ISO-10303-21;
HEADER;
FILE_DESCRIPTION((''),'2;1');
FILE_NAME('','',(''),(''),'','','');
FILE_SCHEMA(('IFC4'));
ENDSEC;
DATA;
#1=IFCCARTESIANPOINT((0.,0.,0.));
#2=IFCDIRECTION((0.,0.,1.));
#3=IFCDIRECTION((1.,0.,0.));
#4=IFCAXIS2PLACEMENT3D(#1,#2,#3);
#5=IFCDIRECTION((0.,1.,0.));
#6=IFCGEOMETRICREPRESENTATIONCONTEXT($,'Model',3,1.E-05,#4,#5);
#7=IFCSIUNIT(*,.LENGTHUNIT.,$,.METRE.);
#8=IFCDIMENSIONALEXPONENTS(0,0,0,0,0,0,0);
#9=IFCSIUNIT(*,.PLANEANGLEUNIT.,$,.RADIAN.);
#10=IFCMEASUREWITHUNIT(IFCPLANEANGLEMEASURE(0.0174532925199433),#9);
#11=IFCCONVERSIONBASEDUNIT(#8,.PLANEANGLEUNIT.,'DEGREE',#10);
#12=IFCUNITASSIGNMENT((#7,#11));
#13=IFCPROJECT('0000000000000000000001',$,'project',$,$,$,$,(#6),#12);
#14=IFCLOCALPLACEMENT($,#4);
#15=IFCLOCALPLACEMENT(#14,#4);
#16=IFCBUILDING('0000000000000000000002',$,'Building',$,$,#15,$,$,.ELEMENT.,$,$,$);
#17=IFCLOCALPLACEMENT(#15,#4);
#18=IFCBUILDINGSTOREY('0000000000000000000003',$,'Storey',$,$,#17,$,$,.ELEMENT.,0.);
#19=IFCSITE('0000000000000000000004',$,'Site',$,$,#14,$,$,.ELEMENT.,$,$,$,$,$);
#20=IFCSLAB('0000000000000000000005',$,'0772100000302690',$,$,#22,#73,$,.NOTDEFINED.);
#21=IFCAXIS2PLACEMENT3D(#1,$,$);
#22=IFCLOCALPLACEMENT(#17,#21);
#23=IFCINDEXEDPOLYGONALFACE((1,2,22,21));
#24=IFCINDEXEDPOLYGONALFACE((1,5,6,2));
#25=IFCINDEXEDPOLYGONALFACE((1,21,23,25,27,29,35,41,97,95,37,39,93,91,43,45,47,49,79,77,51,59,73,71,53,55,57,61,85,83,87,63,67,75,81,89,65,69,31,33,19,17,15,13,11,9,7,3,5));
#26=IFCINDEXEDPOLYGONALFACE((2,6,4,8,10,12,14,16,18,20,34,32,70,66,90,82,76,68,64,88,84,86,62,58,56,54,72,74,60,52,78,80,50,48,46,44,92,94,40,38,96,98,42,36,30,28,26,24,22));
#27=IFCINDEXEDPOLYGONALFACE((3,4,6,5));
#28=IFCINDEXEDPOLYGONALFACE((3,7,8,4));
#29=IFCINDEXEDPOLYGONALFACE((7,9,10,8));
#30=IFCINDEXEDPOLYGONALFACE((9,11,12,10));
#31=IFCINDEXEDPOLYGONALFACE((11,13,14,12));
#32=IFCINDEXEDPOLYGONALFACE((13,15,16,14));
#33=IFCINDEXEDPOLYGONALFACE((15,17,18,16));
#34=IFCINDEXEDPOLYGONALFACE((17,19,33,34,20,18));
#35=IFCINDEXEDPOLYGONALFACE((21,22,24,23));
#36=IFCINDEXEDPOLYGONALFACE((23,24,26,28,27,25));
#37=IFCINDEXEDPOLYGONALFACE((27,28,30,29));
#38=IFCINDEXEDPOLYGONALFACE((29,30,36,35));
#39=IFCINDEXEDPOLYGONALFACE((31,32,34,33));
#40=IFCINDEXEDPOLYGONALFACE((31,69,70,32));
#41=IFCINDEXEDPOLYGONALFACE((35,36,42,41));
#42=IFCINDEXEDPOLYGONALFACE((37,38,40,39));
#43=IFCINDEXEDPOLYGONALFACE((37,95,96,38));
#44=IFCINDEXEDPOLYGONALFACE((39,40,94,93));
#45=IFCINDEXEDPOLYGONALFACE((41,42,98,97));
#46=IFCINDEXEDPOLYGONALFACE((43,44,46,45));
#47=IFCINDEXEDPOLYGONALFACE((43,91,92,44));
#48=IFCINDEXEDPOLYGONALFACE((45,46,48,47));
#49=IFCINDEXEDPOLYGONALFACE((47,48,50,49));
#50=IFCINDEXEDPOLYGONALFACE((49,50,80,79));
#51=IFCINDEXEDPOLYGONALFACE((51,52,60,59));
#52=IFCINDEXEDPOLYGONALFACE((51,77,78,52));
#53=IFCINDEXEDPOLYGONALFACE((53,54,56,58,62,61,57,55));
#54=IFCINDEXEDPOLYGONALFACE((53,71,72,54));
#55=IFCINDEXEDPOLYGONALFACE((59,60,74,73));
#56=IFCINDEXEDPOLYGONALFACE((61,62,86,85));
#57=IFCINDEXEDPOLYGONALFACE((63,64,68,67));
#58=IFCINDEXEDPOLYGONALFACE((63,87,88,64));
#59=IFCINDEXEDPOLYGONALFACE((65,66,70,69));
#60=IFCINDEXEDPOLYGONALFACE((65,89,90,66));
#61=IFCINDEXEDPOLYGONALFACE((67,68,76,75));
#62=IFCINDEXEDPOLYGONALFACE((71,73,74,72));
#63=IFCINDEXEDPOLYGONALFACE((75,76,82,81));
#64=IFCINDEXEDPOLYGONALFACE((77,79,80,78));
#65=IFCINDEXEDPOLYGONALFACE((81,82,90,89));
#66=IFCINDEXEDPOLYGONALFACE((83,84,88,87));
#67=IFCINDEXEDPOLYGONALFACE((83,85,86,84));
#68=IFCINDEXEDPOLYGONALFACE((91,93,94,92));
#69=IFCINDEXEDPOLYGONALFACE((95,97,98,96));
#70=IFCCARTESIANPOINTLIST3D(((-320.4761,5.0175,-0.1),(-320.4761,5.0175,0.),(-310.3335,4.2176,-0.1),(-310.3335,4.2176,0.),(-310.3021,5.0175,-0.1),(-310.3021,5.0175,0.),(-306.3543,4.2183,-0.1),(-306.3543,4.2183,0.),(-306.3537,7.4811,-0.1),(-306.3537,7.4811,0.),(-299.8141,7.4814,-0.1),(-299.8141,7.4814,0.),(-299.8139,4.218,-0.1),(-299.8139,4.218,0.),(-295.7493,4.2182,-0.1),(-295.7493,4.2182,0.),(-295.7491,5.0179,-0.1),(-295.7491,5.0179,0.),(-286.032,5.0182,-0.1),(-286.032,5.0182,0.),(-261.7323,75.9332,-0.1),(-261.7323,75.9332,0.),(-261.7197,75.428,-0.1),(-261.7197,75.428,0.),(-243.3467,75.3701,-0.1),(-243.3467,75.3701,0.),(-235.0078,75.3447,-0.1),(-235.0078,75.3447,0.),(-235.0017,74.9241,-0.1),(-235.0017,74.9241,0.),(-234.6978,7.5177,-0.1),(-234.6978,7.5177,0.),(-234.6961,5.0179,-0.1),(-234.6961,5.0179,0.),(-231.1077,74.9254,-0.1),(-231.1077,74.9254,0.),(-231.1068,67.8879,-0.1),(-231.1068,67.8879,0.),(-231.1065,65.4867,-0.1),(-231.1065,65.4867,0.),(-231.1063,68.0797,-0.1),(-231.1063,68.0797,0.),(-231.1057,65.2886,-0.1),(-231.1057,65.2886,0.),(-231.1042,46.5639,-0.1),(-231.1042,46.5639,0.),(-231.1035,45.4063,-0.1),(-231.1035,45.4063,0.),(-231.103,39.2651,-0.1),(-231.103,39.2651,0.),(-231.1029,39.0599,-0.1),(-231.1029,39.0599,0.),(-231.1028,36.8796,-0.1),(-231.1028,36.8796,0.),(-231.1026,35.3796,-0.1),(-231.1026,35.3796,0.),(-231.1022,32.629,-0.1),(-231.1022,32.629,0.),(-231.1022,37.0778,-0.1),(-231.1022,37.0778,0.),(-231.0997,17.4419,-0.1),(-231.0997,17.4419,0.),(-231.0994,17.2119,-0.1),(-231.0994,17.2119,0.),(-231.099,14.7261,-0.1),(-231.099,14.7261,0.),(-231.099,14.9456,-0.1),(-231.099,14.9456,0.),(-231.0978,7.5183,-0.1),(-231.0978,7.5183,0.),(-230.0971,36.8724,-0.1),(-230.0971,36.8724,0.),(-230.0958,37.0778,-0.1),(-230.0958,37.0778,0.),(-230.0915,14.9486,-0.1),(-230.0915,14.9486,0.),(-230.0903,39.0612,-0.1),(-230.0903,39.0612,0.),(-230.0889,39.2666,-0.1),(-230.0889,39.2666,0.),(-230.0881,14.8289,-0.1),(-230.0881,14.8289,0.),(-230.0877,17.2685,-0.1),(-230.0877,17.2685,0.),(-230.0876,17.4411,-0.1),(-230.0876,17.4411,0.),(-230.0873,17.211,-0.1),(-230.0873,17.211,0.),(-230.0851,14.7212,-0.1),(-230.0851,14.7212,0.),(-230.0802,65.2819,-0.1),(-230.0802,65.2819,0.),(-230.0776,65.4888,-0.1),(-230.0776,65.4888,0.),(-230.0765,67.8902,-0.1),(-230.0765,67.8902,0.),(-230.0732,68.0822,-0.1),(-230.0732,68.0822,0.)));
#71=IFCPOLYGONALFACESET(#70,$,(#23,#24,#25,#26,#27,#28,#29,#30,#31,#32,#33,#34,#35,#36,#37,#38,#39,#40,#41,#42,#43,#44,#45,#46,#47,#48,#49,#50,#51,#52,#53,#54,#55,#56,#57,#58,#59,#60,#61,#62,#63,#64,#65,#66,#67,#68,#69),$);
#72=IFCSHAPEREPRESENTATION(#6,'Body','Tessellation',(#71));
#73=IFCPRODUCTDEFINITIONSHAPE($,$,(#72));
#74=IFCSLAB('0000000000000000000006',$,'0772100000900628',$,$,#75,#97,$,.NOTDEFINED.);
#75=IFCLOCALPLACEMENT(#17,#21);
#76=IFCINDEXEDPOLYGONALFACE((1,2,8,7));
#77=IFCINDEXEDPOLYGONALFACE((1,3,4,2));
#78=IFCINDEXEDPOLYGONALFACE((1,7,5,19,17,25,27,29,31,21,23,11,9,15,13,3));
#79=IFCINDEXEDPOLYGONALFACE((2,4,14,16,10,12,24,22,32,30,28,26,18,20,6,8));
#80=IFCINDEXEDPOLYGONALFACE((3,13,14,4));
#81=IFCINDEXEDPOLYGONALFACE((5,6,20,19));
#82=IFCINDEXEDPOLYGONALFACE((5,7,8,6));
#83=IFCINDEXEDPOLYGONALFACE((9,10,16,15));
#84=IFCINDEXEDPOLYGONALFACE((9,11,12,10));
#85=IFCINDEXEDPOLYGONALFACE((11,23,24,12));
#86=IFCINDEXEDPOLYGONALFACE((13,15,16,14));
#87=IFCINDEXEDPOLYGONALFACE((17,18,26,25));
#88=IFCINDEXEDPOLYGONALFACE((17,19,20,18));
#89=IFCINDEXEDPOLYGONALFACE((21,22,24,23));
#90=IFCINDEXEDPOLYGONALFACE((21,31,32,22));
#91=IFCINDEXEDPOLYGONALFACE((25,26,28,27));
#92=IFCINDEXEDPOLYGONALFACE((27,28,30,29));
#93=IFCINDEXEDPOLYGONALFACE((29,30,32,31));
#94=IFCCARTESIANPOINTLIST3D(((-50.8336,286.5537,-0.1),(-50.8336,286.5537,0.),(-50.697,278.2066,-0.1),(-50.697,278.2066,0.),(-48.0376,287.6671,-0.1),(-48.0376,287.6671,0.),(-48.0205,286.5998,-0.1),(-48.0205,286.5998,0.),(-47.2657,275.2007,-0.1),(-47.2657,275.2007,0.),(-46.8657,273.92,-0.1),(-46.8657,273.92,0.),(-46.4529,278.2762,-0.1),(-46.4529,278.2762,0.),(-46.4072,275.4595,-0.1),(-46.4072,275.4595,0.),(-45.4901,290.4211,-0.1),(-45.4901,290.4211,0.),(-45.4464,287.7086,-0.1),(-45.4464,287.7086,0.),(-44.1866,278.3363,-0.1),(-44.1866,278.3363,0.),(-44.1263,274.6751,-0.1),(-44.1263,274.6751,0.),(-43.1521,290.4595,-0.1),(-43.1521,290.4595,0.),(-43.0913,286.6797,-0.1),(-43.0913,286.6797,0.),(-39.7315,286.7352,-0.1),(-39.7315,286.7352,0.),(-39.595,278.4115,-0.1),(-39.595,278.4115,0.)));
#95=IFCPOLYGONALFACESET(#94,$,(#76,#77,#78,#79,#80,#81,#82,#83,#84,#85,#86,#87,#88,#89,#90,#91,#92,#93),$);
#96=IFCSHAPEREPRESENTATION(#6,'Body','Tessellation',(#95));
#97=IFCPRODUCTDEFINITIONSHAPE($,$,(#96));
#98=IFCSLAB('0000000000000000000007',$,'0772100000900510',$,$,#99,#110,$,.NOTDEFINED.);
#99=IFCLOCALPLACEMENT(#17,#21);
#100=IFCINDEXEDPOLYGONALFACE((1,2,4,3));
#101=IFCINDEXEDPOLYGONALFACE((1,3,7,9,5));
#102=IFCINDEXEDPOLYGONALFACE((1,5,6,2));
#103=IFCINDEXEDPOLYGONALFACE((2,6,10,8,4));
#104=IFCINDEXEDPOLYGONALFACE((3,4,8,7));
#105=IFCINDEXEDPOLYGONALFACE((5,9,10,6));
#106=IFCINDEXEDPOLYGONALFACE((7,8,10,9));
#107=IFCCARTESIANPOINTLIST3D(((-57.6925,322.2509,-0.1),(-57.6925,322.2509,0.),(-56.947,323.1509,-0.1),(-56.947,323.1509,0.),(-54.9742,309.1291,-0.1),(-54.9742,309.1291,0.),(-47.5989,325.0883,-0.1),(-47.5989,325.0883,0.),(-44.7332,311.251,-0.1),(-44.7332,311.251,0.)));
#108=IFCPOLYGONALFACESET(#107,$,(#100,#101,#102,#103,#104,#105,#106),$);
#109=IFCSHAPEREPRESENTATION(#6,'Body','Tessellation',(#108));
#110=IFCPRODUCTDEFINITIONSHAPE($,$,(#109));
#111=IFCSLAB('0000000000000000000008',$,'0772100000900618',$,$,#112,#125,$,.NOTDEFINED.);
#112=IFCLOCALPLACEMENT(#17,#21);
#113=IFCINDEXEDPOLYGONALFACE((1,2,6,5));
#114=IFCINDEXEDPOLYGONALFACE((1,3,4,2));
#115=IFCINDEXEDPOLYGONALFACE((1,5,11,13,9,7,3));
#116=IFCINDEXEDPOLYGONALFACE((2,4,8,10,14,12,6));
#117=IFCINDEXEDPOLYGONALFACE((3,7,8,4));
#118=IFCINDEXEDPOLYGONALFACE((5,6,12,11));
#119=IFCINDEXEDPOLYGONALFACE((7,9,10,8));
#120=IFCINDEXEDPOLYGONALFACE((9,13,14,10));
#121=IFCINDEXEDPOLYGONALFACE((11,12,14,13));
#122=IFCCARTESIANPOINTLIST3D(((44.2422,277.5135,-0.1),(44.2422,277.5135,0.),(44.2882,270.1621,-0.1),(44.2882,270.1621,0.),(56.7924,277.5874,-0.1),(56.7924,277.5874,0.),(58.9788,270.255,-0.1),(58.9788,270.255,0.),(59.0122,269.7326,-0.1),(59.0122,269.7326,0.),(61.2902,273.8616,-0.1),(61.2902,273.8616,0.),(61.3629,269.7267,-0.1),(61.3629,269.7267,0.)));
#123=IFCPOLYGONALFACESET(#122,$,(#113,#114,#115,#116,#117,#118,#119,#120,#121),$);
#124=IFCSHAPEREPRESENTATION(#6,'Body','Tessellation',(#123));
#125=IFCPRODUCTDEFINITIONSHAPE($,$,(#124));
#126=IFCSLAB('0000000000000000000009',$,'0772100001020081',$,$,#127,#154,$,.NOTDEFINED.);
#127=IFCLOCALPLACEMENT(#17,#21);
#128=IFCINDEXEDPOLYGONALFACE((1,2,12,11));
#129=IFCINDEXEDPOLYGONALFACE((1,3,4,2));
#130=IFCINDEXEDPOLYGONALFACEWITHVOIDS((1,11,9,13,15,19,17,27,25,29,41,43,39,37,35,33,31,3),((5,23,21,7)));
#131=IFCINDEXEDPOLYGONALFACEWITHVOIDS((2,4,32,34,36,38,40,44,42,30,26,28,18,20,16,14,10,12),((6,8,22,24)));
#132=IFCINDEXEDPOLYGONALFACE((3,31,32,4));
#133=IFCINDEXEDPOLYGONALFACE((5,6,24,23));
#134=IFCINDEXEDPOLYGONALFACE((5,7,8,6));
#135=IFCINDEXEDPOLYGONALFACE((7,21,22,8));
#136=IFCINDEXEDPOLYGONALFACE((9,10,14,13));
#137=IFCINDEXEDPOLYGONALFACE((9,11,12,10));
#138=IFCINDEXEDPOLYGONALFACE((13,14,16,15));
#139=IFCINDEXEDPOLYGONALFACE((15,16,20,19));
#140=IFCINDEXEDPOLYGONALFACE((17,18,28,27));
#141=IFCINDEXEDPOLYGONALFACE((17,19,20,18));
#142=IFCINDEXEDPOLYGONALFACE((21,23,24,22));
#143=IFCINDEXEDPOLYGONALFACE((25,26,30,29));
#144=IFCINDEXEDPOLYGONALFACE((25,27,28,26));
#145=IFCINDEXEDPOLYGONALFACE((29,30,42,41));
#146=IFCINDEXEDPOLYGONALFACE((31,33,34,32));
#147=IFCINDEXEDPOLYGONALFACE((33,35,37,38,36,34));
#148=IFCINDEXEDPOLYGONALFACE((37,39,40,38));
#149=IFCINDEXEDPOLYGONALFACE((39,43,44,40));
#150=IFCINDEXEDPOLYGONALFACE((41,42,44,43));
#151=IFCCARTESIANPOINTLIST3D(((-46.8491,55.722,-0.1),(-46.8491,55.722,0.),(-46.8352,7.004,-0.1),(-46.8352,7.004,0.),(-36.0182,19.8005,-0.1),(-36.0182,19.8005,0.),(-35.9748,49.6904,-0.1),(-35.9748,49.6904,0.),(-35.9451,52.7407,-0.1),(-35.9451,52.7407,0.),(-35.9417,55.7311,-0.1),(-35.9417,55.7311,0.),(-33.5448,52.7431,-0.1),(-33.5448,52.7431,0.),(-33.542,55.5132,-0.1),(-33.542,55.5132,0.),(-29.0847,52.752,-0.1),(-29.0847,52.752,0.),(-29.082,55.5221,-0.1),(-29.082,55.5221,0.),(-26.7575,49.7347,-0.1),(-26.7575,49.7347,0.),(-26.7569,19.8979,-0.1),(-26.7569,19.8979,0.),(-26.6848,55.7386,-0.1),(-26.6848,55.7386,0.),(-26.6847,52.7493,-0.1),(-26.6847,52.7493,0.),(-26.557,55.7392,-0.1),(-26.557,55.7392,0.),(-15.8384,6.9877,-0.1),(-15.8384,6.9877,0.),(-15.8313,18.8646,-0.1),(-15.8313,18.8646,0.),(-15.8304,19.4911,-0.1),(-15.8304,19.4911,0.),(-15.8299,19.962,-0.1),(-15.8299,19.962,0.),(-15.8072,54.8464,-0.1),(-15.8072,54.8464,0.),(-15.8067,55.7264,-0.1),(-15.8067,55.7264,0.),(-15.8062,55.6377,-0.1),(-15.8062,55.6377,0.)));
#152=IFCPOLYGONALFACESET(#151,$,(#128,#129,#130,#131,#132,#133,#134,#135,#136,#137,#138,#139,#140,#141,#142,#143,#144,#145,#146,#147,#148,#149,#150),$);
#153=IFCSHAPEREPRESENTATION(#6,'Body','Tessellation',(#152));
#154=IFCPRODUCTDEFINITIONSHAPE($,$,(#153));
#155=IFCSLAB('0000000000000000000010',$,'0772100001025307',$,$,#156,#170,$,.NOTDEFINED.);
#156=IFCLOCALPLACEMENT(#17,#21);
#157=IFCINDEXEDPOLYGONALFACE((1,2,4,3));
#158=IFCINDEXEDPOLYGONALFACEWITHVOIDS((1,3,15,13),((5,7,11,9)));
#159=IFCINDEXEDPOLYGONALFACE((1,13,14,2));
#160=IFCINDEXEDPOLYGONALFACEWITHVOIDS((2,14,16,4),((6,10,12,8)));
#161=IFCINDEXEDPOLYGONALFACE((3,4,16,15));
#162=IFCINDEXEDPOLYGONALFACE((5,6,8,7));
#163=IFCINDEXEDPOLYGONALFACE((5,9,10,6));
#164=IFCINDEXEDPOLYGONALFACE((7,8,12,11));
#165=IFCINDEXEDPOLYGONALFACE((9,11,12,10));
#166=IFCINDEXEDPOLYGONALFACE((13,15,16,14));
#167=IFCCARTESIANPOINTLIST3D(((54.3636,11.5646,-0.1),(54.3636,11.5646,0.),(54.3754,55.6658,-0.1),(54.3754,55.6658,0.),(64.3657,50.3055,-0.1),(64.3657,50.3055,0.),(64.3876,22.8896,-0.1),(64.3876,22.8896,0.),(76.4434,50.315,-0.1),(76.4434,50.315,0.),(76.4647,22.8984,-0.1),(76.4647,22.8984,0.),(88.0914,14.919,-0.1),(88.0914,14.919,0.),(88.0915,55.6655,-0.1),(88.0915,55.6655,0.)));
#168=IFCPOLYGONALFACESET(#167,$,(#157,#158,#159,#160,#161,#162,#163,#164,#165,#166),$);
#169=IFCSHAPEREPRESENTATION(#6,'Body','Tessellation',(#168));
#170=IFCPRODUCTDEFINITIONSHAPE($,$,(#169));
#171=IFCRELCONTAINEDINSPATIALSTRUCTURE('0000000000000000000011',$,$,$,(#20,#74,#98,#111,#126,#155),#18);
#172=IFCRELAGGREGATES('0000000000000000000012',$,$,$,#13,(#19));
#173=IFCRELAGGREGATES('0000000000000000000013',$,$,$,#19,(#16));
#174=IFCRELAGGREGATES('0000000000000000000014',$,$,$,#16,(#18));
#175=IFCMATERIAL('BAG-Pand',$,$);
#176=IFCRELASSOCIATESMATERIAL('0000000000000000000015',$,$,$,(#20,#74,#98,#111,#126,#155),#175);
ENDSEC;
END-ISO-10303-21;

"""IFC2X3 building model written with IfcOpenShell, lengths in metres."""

from ifc_helpers import new_model, entity, si_unit, converted_unit, direction, frame, origin_with_axes, place, context, project, spatial, polyline, outline, extrude, material, element, save


model = new_model("IFC2X3")

# Units and contexts
model_context = context("Model", 3, precision=1e-05, world=origin_with_axes(), true_north=direction((0.0, 1.0, 0.0)))
ifc_project = project(units=[si_unit("LENGTHUNIT", "METRE"), converted_unit("PLANEANGLEUNIT", "DEGREE", entity("IfcPlaneAngleMeasure", 0.0174532925199433), si_unit("PLANEANGLEUNIT", "RADIAN"), dimensions=[0, 0, 0, 0, 0, 0, 0])], contexts=[model_context])

# Site, building, storey
site_placement = place(None, origin_with_axes())
site = spatial("IfcSite", under=ifc_project, at=site_placement, Name="Site", CompositionType="ELEMENT")
building_placement = place(site_placement, origin_with_axes())
building = spatial("IfcBuilding", under=site, at=building_placement, Name="Building", CompositionType="ELEMENT")
storey_placement = place(building_placement, origin_with_axes())
storey = spatial("IfcBuildingStorey", under=building, at=storey_placement, Name="Storey", CompositionType="ELEMENT", Elevation=0.0)

# Slabs
ifc_material = material(Name="BAG-Pand")
slab_1_placement = place(storey_placement, frame((0.0, 0.0, -0.1), z_axis=(0.0, 0.0, 1.0), x_axis=(1.0, 0.0, 0.0)))
element("IfcSlab", 1, at=slab_1_placement, inside=storey, material=ifc_material, Name="0772100000302690", PredefinedType="NOTDEFINED", context=model_context, shape_type="SweptSolid", body=[
    extrude(outline(polyline([(-261.7197, 75.428), (-243.3467, 75.3701), (-235.0078, 75.3447), (-235.0017, 74.9241), (-231.1077, 74.9254), (-231.1063, 68.0797), (-230.0732, 68.0822), (-230.0765, 67.8902), (-231.1068, 67.8879), (-231.1065, 65.4867), (-230.0776, 65.4888), (-230.0802, 65.2819), (-231.1057, 65.2886), (-231.1042, 46.5639), (-231.1035, 45.4063), (-231.103, 39.2651), (-230.0889, 39.2666), (-230.0903, 39.0612), (-231.1029, 39.0599), (-231.1022, 37.0778), (-230.0958, 37.0778), (-230.0971, 36.8724), (-231.1028, 36.8796), (-231.1026, 35.3796), (-231.1022, 32.629), (-231.0997, 17.4419), (-230.0876, 17.4411), (-230.0877, 17.2685), (-230.0873, 17.211), (-231.0994, 17.2119), (-231.099, 14.9456), (-230.0915, 14.9486), (-230.0881, 14.8289), (-230.0851, 14.7212), (-231.099, 14.7261), (-231.0978, 7.5183), (-234.6978, 7.5177), (-234.6961, 5.0179), (-286.032, 5.0182), (-295.7491, 5.0179), (-295.7493, 4.2182), (-299.8139, 4.218), (-299.8141, 7.4814), (-306.3537, 7.4811), (-306.3543, 4.2183), (-310.3335, 4.2176), (-310.3021, 5.0175), (-320.4761, 5.0175), (-261.7323, 75.9332), (-261.7197, 75.428)])), origin_with_axes(), (0.0, 0.0, 1.0), 0.1),
])
slab_2_placement = place(storey_placement, frame((0.0, 0.0, -0.1), z_axis=(0.0, 0.0, 1.0), x_axis=(1.0, 0.0, 0.0)))
element("IfcSlab", 2, at=slab_2_placement, inside=storey, material=ifc_material, Name="0772100000900628", PredefinedType="NOTDEFINED", context=model_context, shape_type="SweptSolid", body=[
    extrude(outline(polyline([(-48.0376, 287.6671), (-45.4464, 287.7086), (-45.4901, 290.4211), (-43.1521, 290.4595), (-43.0913, 286.6797), (-39.7315, 286.7352), (-39.595, 278.4115), (-44.1866, 278.3363), (-44.1263, 274.6751), (-46.8657, 273.92), (-47.2657, 275.2007), (-46.4072, 275.4595), (-46.4529, 278.2762), (-50.697, 278.2066), (-50.8336, 286.5537), (-48.0205, 286.5998), (-48.0376, 287.6671)])), origin_with_axes(), (0.0, 0.0, 1.0), 0.1),
])
slab_3_placement = place(storey_placement, frame((0.0, 0.0, -0.1), z_axis=(0.0, 0.0, 1.0), x_axis=(1.0, 0.0, 0.0)))
element("IfcSlab", 3, at=slab_3_placement, inside=storey, material=ifc_material, Name="0772100000900510", PredefinedType="NOTDEFINED", context=model_context, shape_type="SweptSolid", body=[
    extrude(outline(polyline([(-47.5989, 325.0883), (-44.7332, 311.251), (-54.9742, 309.1291), (-57.6925, 322.2509), (-56.947, 323.1509), (-47.5989, 325.0883)])), origin_with_axes(), (0.0, 0.0, 1.0), 0.1),
])
slab_4_placement = place(storey_placement, frame((0.0, 0.0, -0.1), z_axis=(0.0, 0.0, 1.0), x_axis=(1.0, 0.0, 0.0)))
element("IfcSlab", 4, at=slab_4_placement, inside=storey, material=ifc_material, Name="0772100000900618", PredefinedType="NOTDEFINED", context=model_context, shape_type="SweptSolid", body=[
    extrude(outline(polyline([(61.3629, 269.7267), (59.0122, 269.7326), (58.9788, 270.255), (44.2882, 270.1621), (44.2422, 277.5135), (56.7924, 277.5874), (61.2902, 273.8616), (61.3629, 269.7267)])), origin_with_axes(), (0.0, 0.0, 1.0), 0.1),
])
slab_5_placement = place(storey_placement, frame((0.0, 0.0, -0.1), z_axis=(0.0, 0.0, 1.0), x_axis=(1.0, 0.0, 0.0)))
element("IfcSlab", 5, at=slab_5_placement, inside=storey, material=ifc_material, Name="0772100001020081", PredefinedType="NOTDEFINED", context=model_context, shape_type="SweptSolid", body=[
    extrude(outline(polyline([(-46.8491, 55.722), (-35.9417, 55.7311), (-35.9451, 52.7407), (-33.5448, 52.7431), (-33.542, 55.5132), (-29.082, 55.5221), (-29.0847, 52.752), (-26.6847, 52.7493), (-26.6848, 55.7386), (-26.557, 55.7392), (-15.8067, 55.7264), (-15.8062, 55.6377), (-15.8072, 54.8464), (-15.8299, 19.962), (-15.8304, 19.4911), (-15.8313, 18.8646), (-15.8384, 6.9877), (-46.8352, 7.004), (-46.8491, 55.722)]), holes=[polyline([(-26.7569, 19.8979), (-26.7575, 49.7347), (-35.9748, 49.6904), (-36.0182, 19.8005), (-26.7569, 19.8979)])]), origin_with_axes(), (0.0, 0.0, 1.0), 0.1),
])
slab_6_placement = place(storey_placement, frame((0.0, 0.0, -0.1), z_axis=(0.0, 0.0, 1.0), x_axis=(1.0, 0.0, 0.0)))
element("IfcSlab", 6, at=slab_6_placement, inside=storey, material=ifc_material, Name="0772100001025307", PredefinedType="NOTDEFINED", context=model_context, shape_type="SweptSolid", body=[
    extrude(outline(polyline([(54.3754, 55.6658), (88.0915, 55.6655), (88.0914, 14.919), (54.3636, 11.5646), (54.3754, 55.6658)]), holes=[polyline([(76.4647, 22.8984), (76.4434, 50.315), (64.3657, 50.3055), (64.3876, 22.8896), (76.4647, 22.8984)])]), origin_with_axes(), (0.0, 0.0, 1.0), 0.1),
])

save(model, "model.ifc")
